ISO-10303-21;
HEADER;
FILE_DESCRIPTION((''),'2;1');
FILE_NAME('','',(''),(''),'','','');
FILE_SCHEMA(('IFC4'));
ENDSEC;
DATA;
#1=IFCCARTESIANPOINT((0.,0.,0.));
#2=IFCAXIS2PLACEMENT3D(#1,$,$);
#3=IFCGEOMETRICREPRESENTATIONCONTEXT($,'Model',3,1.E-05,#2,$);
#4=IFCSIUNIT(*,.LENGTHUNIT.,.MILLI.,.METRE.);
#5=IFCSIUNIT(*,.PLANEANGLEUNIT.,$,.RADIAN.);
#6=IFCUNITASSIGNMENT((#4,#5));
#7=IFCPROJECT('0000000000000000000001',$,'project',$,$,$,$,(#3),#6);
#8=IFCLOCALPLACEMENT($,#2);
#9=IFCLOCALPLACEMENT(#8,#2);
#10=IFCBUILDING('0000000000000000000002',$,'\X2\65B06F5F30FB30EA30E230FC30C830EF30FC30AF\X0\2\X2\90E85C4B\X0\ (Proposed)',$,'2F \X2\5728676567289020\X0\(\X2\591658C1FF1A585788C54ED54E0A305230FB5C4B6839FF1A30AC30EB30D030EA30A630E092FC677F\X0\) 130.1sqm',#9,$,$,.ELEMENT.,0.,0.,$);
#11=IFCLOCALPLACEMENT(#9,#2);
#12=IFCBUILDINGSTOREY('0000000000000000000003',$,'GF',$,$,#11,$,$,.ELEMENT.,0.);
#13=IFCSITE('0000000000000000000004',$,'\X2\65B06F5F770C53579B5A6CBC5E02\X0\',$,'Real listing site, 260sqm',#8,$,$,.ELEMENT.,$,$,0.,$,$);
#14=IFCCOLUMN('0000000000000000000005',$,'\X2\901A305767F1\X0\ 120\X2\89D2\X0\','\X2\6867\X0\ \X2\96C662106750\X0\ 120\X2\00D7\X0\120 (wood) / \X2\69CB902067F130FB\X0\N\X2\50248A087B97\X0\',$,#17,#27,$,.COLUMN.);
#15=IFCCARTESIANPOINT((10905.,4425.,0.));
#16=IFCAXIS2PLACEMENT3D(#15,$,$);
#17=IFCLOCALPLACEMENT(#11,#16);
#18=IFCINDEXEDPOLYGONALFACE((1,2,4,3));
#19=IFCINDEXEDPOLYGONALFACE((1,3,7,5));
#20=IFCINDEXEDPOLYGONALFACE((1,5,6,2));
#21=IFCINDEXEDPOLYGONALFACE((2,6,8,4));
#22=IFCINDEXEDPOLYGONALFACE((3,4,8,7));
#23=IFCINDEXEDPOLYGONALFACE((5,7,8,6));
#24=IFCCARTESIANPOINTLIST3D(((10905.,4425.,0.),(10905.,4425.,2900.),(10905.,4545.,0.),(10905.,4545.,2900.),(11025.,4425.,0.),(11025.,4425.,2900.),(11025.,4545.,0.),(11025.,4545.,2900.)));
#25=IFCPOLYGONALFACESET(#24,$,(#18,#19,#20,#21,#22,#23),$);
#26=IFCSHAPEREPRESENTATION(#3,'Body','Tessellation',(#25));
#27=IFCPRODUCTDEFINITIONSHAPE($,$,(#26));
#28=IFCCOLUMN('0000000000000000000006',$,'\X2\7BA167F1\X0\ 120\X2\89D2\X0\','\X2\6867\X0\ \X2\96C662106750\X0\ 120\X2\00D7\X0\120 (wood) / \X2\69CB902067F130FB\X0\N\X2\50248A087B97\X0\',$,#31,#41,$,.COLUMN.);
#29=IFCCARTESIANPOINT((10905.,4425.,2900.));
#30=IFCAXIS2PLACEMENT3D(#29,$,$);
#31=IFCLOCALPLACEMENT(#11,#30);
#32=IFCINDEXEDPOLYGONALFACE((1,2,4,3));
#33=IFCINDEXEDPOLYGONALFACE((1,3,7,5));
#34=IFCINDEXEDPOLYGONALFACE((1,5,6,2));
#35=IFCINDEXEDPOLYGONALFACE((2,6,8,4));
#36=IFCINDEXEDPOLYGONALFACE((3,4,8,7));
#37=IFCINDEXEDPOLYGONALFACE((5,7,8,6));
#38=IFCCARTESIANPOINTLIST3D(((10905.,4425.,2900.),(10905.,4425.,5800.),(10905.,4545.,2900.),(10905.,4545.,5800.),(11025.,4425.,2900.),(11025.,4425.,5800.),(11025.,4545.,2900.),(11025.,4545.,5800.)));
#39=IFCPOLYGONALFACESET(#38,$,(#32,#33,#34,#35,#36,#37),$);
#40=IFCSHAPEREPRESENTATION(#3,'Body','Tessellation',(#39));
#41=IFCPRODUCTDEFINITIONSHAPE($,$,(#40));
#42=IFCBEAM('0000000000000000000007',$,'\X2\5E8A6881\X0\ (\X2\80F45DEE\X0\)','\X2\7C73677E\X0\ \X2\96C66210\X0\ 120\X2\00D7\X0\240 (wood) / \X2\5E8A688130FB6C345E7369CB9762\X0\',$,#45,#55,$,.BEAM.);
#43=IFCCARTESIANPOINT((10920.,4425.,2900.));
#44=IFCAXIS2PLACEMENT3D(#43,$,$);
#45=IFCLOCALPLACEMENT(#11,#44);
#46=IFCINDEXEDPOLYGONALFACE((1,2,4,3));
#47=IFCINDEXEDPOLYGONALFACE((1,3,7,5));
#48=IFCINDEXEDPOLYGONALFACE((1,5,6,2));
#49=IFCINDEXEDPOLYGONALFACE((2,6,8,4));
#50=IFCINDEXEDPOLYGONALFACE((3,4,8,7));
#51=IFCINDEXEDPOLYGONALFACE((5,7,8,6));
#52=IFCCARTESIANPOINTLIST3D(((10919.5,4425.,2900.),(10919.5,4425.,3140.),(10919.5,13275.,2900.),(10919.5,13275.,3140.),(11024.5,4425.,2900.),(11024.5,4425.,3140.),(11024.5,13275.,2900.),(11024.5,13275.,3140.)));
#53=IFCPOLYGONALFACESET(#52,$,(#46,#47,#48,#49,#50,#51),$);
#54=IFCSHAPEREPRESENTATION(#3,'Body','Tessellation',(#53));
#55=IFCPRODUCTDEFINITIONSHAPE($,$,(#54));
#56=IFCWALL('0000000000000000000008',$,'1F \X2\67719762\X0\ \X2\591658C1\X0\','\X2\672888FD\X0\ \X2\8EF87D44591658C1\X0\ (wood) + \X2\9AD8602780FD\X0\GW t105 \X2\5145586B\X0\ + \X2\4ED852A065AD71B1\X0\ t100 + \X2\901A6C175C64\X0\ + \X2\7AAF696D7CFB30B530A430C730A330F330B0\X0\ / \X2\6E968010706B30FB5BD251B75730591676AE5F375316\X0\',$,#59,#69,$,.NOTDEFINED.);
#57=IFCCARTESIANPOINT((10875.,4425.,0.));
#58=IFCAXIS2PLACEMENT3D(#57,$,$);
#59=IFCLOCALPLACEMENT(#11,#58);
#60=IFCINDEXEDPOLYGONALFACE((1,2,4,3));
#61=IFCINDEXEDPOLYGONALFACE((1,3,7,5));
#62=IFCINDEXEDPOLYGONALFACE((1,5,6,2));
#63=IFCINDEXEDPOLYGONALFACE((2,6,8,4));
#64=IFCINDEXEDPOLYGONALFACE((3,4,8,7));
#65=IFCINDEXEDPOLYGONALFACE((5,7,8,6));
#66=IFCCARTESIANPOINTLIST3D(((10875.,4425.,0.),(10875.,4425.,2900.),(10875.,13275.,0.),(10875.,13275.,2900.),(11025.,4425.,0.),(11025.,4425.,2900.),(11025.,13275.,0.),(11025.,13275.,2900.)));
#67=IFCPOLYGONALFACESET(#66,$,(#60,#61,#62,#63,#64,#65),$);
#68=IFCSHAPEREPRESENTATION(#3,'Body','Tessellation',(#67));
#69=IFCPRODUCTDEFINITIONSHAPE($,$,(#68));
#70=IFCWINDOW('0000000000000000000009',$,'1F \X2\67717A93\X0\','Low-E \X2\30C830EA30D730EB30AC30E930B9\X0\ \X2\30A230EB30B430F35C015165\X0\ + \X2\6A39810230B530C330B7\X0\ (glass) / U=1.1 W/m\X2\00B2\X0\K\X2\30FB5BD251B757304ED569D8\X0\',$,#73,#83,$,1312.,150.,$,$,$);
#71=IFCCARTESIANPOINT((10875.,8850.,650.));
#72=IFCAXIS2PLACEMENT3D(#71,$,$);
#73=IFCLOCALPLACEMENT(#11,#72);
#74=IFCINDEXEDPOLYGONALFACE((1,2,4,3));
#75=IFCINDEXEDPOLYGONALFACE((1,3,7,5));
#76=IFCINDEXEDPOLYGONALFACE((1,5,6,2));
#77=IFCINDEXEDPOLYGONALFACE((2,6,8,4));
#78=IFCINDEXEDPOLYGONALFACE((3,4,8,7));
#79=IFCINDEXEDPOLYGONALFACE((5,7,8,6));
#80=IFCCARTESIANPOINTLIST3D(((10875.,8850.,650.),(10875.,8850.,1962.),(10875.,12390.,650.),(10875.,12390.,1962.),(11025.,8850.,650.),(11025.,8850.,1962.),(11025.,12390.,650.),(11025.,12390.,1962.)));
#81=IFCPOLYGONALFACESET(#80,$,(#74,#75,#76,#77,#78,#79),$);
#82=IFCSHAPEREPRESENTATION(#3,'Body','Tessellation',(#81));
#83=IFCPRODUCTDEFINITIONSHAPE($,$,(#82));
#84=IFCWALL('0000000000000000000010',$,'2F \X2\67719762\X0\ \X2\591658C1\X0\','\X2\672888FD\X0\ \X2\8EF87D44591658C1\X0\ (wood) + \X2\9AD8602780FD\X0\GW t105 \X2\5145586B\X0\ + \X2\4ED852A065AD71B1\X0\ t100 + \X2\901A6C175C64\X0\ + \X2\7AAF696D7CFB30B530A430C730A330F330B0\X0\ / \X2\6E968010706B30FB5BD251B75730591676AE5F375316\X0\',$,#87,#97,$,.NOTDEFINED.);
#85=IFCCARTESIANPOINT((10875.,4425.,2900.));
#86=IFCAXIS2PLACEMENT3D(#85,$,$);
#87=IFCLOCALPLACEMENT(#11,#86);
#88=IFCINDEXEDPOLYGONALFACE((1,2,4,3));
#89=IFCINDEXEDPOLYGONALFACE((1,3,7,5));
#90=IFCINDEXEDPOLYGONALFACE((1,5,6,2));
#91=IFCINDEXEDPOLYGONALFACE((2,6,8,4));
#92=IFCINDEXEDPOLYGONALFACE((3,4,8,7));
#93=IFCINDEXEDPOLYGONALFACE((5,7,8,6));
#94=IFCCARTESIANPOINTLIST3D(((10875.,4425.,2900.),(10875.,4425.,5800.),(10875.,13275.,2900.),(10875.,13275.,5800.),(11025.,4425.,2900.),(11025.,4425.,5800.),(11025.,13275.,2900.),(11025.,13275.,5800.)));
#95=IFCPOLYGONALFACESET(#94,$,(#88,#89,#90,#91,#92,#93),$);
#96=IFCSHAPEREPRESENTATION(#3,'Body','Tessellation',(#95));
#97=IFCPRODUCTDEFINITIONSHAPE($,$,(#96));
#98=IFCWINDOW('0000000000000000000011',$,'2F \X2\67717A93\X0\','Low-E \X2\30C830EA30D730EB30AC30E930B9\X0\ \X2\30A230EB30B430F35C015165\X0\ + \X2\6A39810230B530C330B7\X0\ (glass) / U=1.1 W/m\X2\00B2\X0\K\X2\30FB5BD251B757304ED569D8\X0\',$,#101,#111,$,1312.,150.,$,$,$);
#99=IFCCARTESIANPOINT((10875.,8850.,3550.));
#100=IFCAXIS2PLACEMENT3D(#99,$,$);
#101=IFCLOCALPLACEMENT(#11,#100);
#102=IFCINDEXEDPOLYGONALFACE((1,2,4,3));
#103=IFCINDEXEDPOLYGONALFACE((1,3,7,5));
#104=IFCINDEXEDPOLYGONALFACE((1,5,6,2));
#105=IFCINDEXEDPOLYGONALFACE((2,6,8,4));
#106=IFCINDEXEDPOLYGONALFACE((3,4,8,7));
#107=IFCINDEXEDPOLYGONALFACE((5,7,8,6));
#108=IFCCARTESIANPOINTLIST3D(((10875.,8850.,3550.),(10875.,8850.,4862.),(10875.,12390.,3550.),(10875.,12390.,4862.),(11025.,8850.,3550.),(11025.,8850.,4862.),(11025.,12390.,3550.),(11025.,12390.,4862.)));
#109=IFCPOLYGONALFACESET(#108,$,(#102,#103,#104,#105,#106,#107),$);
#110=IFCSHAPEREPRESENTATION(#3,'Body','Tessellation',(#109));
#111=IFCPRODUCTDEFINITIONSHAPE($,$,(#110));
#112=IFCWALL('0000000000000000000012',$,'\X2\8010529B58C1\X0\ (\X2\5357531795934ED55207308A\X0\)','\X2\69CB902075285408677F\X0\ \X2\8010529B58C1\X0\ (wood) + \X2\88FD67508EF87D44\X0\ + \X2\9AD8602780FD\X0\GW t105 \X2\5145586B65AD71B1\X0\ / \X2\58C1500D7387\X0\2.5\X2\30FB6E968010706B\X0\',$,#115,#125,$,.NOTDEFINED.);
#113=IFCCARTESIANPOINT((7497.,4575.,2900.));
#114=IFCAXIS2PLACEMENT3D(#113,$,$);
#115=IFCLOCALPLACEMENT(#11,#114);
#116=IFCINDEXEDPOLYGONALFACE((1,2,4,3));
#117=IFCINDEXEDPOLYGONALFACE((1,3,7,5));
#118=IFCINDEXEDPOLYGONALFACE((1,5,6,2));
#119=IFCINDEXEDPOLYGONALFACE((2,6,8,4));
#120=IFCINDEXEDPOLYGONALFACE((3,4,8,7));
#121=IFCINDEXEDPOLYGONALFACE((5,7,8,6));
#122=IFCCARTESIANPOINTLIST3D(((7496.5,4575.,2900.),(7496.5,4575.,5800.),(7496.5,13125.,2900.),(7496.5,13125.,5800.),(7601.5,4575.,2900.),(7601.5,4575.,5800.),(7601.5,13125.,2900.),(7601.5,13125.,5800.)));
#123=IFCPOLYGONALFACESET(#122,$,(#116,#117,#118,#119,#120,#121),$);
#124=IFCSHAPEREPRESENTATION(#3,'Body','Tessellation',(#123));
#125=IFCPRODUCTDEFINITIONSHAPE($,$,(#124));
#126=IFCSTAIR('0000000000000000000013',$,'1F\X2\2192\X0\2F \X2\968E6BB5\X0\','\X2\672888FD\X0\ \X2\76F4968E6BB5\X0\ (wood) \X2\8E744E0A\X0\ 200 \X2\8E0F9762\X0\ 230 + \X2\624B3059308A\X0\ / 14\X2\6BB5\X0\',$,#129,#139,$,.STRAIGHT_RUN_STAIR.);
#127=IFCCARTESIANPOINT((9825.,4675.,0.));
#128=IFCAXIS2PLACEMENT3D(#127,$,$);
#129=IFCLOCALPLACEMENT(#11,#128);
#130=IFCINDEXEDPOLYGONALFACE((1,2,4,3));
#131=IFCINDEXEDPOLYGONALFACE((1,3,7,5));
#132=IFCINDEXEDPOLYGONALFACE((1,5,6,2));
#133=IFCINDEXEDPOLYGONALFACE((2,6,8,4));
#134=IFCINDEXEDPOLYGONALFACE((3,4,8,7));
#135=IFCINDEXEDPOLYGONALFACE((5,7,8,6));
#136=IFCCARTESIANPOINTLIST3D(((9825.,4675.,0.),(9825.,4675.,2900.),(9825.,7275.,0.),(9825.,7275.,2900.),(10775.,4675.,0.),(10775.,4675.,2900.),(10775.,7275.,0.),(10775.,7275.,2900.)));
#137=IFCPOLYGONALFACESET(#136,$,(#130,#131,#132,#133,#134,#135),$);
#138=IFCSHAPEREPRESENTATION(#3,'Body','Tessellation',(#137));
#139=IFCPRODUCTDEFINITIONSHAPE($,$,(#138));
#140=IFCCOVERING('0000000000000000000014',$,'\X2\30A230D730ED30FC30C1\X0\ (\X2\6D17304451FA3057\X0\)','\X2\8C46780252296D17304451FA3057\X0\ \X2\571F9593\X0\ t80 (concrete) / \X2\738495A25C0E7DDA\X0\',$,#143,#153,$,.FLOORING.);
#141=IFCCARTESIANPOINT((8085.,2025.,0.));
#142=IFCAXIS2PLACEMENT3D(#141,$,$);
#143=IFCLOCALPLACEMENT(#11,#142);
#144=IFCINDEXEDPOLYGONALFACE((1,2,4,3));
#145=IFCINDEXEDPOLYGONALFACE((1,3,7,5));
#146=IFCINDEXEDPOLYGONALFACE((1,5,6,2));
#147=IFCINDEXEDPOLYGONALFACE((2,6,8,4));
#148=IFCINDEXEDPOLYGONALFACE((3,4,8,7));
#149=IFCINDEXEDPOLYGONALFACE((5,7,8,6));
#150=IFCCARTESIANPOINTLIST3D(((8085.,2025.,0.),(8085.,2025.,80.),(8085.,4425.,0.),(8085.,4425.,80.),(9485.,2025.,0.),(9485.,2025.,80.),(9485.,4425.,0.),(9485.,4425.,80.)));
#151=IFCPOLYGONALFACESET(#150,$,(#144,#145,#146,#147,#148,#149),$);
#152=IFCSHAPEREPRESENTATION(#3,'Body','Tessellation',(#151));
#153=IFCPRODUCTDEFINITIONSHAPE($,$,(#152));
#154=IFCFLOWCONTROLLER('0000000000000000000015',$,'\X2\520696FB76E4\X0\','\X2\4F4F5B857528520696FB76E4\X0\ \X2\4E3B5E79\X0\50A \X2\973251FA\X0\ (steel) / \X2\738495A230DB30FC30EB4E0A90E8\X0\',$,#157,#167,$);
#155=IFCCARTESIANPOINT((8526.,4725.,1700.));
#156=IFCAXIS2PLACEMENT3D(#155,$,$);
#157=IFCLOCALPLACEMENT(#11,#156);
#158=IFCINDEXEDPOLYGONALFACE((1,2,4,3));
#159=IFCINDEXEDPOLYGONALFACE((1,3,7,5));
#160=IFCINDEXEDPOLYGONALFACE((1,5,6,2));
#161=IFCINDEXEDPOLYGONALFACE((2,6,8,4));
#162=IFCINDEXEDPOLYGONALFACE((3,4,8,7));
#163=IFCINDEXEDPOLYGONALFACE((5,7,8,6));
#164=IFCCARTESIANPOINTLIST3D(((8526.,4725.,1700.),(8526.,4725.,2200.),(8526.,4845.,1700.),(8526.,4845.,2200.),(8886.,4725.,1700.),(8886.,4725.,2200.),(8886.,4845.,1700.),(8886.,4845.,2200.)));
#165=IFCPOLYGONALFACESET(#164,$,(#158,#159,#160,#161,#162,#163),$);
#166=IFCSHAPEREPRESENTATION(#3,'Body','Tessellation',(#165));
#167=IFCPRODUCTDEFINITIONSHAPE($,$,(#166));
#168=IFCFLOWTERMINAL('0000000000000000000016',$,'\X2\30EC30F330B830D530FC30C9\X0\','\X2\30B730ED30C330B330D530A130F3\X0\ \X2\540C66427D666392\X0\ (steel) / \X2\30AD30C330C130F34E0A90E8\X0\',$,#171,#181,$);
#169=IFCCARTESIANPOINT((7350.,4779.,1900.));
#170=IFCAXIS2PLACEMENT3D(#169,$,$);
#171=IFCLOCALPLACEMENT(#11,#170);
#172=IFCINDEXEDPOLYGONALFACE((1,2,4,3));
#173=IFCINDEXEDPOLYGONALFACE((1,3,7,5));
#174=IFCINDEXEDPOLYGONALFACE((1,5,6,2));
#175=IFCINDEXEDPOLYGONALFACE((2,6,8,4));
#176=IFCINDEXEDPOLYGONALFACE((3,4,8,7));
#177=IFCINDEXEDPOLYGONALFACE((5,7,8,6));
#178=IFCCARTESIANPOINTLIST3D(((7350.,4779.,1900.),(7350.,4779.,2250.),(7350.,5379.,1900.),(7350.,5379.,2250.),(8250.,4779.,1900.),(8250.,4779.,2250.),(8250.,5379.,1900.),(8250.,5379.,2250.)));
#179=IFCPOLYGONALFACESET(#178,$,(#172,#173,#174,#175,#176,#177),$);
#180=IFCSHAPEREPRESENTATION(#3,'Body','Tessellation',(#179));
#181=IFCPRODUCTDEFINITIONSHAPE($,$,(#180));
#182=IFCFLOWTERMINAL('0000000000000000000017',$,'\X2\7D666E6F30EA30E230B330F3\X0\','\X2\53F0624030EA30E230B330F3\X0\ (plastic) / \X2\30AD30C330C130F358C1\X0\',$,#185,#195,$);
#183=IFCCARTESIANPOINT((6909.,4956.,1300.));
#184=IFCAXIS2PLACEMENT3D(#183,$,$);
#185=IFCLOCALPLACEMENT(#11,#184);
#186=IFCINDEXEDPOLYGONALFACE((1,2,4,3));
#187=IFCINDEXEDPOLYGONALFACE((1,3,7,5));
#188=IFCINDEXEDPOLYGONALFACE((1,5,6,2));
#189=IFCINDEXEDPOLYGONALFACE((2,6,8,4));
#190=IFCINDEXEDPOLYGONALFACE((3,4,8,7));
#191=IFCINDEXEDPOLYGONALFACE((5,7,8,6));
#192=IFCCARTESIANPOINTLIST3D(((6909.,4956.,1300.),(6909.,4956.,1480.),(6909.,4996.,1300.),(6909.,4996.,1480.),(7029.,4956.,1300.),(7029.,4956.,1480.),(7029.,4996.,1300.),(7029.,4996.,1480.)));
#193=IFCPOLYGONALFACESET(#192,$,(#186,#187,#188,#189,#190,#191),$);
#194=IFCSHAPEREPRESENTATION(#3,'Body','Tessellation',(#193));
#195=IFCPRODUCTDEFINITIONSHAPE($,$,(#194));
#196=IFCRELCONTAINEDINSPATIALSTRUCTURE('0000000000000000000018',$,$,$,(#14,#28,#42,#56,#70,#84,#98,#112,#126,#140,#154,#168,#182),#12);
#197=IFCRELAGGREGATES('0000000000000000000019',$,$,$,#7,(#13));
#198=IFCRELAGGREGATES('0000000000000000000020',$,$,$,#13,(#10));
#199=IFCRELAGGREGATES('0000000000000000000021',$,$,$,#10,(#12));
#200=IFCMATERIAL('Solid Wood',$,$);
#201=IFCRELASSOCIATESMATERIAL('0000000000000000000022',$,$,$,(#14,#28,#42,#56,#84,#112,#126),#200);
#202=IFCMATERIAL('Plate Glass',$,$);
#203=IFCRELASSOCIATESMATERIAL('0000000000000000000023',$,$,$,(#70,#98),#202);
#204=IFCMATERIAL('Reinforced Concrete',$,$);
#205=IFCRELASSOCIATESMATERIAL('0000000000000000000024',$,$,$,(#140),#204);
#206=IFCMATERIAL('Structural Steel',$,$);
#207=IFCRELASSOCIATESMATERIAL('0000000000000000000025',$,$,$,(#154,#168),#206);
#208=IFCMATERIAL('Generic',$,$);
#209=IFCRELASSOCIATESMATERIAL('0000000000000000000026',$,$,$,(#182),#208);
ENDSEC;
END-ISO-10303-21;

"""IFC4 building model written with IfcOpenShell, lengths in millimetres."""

from ifc_helpers import new_model, si_unit, frame, frame_2d, origin, place, context, project, spatial, rectangle, extrude, material, element, fill, save


model = new_model("IFC4")

# Units and contexts
model_context = context("Model", 3, precision=1e-05, world=origin())
ifc_project = project(units=[si_unit("LENGTHUNIT", "METRE", prefix="MILLI"), si_unit("PLANEANGLEUNIT", "RADIAN")], contexts=[model_context])

# Site, building, storey
site_placement = place(None, origin())
site = spatial("IfcSite", under=ifc_project, at=site_placement, Name="新潟県南魚沼市", ObjectType="Real listing site, 260sqm", CompositionType="ELEMENT", RefElevation=0.0)
building_placement = place(site_placement, origin())
building = spatial("IfcBuilding", under=site, at=building_placement, Name="新潟・リモートワーク2部屋 (Proposed)", ObjectType="2F 在来木造(外壁：塗装仕上げ・屋根：ガルバリウム鋼板) 130.1sqm", CompositionType="ELEMENT", ElevationOfRefHeight=0.0, ElevationOfTerrain=0.0)
storey_placement = place(building_placement, origin())
storey = spatial("IfcBuildingStorey", under=building, at=storey_placement, Name="GF", CompositionType="ELEMENT", Elevation=0.0)

# Columns
ifc_material_1 = material(Name="Solid Wood")
column_1_placement = place(storey_placement, frame((10905.0, 4425.0, 0.0)))
element("IfcColumn", 1, at=column_1_placement, inside=storey, material=ifc_material_1, Name="通し柱 120角", Description="桧 集成材 120×120 (wood) / 構造柱・N値計算", PredefinedType="COLUMN", context=model_context, shape_type="SweptSolid", body=[
    extrude(rectangle(XDim=120.0, YDim=120.0, at=frame_2d((60.0, 60.0))), frame((10905.0, 4425.0, 0.0)), (0.0, 0.0, 1.0), 2900.0),
])
column_2_placement = place(storey_placement, frame((10905.0, 4425.0, 2900.0)))
element("IfcColumn", 2, at=column_2_placement, inside=storey, material=ifc_material_1, Name="管柱 120角", Description="桧 集成材 120×120 (wood) / 構造柱・N値計算", PredefinedType="COLUMN", context=model_context, shape_type="SweptSolid", body=[
    extrude(rectangle(XDim=120.0, YDim=120.0, at=frame_2d((60.0, 60.0))), frame((10905.0, 4425.0, 2900.0)), (0.0, 0.0, 1.0), 2900.0),
])

# Beam
beam_1_placement = place(storey_placement, frame((10920.0, 4425.0, 2900.0)))
element("IfcBeam", 3, at=beam_1_placement, inside=storey, material=ifc_material_1, Name="床梁 (胴差)", Description="米松 集成 120×240 (wood) / 床梁・水平構面", PredefinedType="BEAM", context=model_context, shape_type="SweptSolid", body=[
    extrude(rectangle(XDim=105.0, YDim=8850.0, at=frame_2d((52.0, 4425.0))), frame((10920.0, 4425.0, 2900.0)), (0.0, 0.0, 1.0), 240.0),
])

# Wall, opening, window
wall_1_placement = place(storey_placement, frame((10875.0, 4425.0, 0.0)))
wall_1 = element("IfcWall", 4, at=wall_1_placement, inside=storey, material=ifc_material_1, Name="1F 東面 外壁", Description="木製 軸組外壁 (wood) + 高性能GW t105 充填 + 付加断熱 t100 + 通気層 + 窯業系サイディング / 準耐火・寒冷地外皮強化", PredefinedType="NOTDEFINED", context=model_context, shape_type="SweptSolid", body=[
    extrude(rectangle(XDim=150.0, YDim=8850.0, at=frame_2d((75.0, 4425.0))), frame((10875.0, 4425.0, 0.0)), (0.0, 0.0, 1.0), 2900.0),
])
opening_1_placement = place(storey_placement, frame((10875.0, 8850.0, 650.0)))
opening_1 = element("IfcOpeningElement", 5, at=opening_1_placement, cuts=wall_1, PredefinedType="NOTDEFINED", context=model_context, shape_type="SweptSolid", body=[
    extrude(rectangle(XDim=150.0, YDim=3540.0, at=frame_2d((75.0, 1770.0))), frame((10875.0, 8850.0, 650.0)), (0.0, 0.0, 1.0), 1312.0),
])
ifc_material_2 = material(Name="Plate Glass")
window_1_placement = place(storey_placement, frame((10875.0, 8850.0, 650.0)))
window_1 = element("IfcWindow", 6, at=window_1_placement, inside=storey, material=ifc_material_2, Name="1F 東窓", Description="Low-E トリプルガラス アルゴン封入 + 樹脂サッシ (glass) / U=1.1 W/m²K・寒冷地仕様", OverallHeight=1312.0, OverallWidth=150.0, context=model_context, shape_type="SweptSolid", body=[
    extrude(rectangle(XDim=150.0, YDim=3540.0, at=frame_2d((75.0, 1770.0))), frame((10875.0, 8850.0, 650.0)), (0.0, 0.0, 1.0), 1312.0),
])
fill(opening_1, window_1)

# Wall, opening, window
wall_2_placement = place(storey_placement, frame((10875.0, 4425.0, 2900.0)))
wall_2 = element("IfcWall", 7, at=wall_2_placement, inside=storey, material=ifc_material_1, Name="2F 東面 外壁", Description="木製 軸組外壁 (wood) + 高性能GW t105 充填 + 付加断熱 t100 + 通気層 + 窯業系サイディング / 準耐火・寒冷地外皮強化", PredefinedType="NOTDEFINED", context=model_context, shape_type="SweptSolid", body=[
    extrude(rectangle(XDim=150.0, YDim=8850.0, at=frame_2d((75.0, 4425.0))), frame((10875.0, 4425.0, 2900.0)), (0.0, 0.0, 1.0), 2900.0),
])
opening_2_placement = place(storey_placement, frame((10875.0, 8850.0, 3550.0)))
opening_2 = element("IfcOpeningElement", 8, at=opening_2_placement, cuts=wall_2, PredefinedType="NOTDEFINED", context=model_context, shape_type="SweptSolid", body=[
    extrude(rectangle(XDim=150.0, YDim=3540.0, at=frame_2d((75.0, 1770.0))), frame((10875.0, 8850.0, 3550.0)), (0.0, 0.0, 1.0), 1312.0),
])
window_2_placement = place(storey_placement, frame((10875.0, 8850.0, 3550.0)))
window_2 = element("IfcWindow", 9, at=window_2_placement, inside=storey, material=ifc_material_2, Name="2F 東窓", Description="Low-E トリプルガラス アルゴン封入 + 樹脂サッシ (glass) / U=1.1 W/m²K・寒冷地仕様", OverallHeight=1312.0, OverallWidth=150.0, context=model_context, shape_type="SweptSolid", body=[
    extrude(rectangle(XDim=150.0, YDim=3540.0, at=frame_2d((75.0, 1770.0))), frame((10875.0, 8850.0, 3550.0)), (0.0, 0.0, 1.0), 1312.0),
])
fill(opening_2, window_2)

# Wall
wall_3_placement = place(storey_placement, frame((7497.0, 4575.0, 2900.0)))
element("IfcWall", 10, at=wall_3_placement, inside=storey, material=ifc_material_1, Name="耐力壁 (南北間仕切り)", Description="構造用合板 耐力壁 (wood) + 製材軸組 + 高性能GW t105 充填断熱 / 壁倍率2.5・準耐火", PredefinedType="NOTDEFINED", context=model_context, shape_type="SweptSolid", body=[
    extrude(rectangle(XDim=105.0, YDim=8550.0, at=frame_2d((52.0, 4275.0))), frame((7497.0, 4575.0, 2900.0)), (0.0, 0.0, 1.0), 2900.0),
])

# Stair
stair_placement = place(storey_placement, frame((9825.0, 4675.0, 0.0)))
element("IfcStair", 11, at=stair_placement, inside=storey, material=ifc_material_1, Name="1F→2F 階段", Description="木製 直階段 (wood) 蹴上 200 踏面 230 + 手すり / 14段", PredefinedType="STRAIGHT_RUN_STAIR", context=model_context, shape_type="SweptSolid", body=[
    extrude(rectangle(XDim=950.0, YDim=2600.0, at=frame_2d((475.0, 1300.0))), frame((9825.0, 4675.0, 0.0)), (0.0, 0.0, 1.0), 2900.0),
])

# Covering
ifc_material_3 = material(Name="Reinforced Concrete")
covering_placement = place(storey_placement, frame((8085.0, 2025.0, 0.0)))
element("IfcCovering", 12, at=covering_placement, inside=storey, material=ifc_material_3, Name="アプローチ (洗い出し)", Description="豆砂利洗い出し 土間 t80 (concrete) / 玄関導線", PredefinedType="FLOORING", context=model_context, shape_type="SweptSolid", body=[
    extrude(rectangle(XDim=1400.0, YDim=2400.0, at=frame_2d((700.0, 1200.0))), frame((8085.0, 2025.0, 0.0)), (0.0, 0.0, 1.0), 80.0),
])

# Flow controller
ifc_material_4 = material(Name="Structural Steel")
flow_controller_placement = place(storey_placement, frame((8526.0, 4725.0, 1700.0)))
element("IfcFlowController", 13, at=flow_controller_placement, inside=storey, material=ifc_material_4, Name="分電盤", Description="住宅用分電盤 主幹50A 露出 (steel) / 玄関ホール上部", context=model_context, shape_type="SweptSolid", body=[
    extrude(rectangle(XDim=360.0, YDim=120.0, at=frame_2d((180.0, 60.0))), frame((8526.0, 4725.0, 1700.0)), (0.0, 0.0, 1.0), 500.0),
])

# Flow terminals
flow_terminal_1_placement = place(storey_placement, frame((7350.0, 4779.0, 1900.0)))
element("IfcFlowTerminal", 14, at=flow_terminal_1_placement, inside=storey, material=ifc_material_4, Name="レンジフード", Description="シロッコファン 同時給排 (steel) / キッチン上部", context=model_context, shape_type="SweptSolid", body=[
    extrude(rectangle(XDim=900.0, YDim=600.0, at=frame_2d((450.0, 300.0))), frame((7350.0, 4779.0, 1900.0)), (0.0, 0.0, 1.0), 350.0),
])
ifc_material_5 = material(Name="Generic")
flow_terminal_2_placement = place(storey_placement, frame((6909.0, 4956.0, 1300.0)))
element("IfcFlowTerminal", 15, at=flow_terminal_2_placement, inside=storey, material=ifc_material_5, Name="給湯リモコン", Description="台所リモコン (plastic) / キッチン壁", context=model_context, shape_type="SweptSolid", body=[
    extrude(rectangle(XDim=120.0, YDim=40.0, at=frame_2d((60.0, 20.0))), frame((6909.0, 4956.0, 1300.0)), (0.0, 0.0, 1.0), 180.0),
])

save(model, "model.ifc")
